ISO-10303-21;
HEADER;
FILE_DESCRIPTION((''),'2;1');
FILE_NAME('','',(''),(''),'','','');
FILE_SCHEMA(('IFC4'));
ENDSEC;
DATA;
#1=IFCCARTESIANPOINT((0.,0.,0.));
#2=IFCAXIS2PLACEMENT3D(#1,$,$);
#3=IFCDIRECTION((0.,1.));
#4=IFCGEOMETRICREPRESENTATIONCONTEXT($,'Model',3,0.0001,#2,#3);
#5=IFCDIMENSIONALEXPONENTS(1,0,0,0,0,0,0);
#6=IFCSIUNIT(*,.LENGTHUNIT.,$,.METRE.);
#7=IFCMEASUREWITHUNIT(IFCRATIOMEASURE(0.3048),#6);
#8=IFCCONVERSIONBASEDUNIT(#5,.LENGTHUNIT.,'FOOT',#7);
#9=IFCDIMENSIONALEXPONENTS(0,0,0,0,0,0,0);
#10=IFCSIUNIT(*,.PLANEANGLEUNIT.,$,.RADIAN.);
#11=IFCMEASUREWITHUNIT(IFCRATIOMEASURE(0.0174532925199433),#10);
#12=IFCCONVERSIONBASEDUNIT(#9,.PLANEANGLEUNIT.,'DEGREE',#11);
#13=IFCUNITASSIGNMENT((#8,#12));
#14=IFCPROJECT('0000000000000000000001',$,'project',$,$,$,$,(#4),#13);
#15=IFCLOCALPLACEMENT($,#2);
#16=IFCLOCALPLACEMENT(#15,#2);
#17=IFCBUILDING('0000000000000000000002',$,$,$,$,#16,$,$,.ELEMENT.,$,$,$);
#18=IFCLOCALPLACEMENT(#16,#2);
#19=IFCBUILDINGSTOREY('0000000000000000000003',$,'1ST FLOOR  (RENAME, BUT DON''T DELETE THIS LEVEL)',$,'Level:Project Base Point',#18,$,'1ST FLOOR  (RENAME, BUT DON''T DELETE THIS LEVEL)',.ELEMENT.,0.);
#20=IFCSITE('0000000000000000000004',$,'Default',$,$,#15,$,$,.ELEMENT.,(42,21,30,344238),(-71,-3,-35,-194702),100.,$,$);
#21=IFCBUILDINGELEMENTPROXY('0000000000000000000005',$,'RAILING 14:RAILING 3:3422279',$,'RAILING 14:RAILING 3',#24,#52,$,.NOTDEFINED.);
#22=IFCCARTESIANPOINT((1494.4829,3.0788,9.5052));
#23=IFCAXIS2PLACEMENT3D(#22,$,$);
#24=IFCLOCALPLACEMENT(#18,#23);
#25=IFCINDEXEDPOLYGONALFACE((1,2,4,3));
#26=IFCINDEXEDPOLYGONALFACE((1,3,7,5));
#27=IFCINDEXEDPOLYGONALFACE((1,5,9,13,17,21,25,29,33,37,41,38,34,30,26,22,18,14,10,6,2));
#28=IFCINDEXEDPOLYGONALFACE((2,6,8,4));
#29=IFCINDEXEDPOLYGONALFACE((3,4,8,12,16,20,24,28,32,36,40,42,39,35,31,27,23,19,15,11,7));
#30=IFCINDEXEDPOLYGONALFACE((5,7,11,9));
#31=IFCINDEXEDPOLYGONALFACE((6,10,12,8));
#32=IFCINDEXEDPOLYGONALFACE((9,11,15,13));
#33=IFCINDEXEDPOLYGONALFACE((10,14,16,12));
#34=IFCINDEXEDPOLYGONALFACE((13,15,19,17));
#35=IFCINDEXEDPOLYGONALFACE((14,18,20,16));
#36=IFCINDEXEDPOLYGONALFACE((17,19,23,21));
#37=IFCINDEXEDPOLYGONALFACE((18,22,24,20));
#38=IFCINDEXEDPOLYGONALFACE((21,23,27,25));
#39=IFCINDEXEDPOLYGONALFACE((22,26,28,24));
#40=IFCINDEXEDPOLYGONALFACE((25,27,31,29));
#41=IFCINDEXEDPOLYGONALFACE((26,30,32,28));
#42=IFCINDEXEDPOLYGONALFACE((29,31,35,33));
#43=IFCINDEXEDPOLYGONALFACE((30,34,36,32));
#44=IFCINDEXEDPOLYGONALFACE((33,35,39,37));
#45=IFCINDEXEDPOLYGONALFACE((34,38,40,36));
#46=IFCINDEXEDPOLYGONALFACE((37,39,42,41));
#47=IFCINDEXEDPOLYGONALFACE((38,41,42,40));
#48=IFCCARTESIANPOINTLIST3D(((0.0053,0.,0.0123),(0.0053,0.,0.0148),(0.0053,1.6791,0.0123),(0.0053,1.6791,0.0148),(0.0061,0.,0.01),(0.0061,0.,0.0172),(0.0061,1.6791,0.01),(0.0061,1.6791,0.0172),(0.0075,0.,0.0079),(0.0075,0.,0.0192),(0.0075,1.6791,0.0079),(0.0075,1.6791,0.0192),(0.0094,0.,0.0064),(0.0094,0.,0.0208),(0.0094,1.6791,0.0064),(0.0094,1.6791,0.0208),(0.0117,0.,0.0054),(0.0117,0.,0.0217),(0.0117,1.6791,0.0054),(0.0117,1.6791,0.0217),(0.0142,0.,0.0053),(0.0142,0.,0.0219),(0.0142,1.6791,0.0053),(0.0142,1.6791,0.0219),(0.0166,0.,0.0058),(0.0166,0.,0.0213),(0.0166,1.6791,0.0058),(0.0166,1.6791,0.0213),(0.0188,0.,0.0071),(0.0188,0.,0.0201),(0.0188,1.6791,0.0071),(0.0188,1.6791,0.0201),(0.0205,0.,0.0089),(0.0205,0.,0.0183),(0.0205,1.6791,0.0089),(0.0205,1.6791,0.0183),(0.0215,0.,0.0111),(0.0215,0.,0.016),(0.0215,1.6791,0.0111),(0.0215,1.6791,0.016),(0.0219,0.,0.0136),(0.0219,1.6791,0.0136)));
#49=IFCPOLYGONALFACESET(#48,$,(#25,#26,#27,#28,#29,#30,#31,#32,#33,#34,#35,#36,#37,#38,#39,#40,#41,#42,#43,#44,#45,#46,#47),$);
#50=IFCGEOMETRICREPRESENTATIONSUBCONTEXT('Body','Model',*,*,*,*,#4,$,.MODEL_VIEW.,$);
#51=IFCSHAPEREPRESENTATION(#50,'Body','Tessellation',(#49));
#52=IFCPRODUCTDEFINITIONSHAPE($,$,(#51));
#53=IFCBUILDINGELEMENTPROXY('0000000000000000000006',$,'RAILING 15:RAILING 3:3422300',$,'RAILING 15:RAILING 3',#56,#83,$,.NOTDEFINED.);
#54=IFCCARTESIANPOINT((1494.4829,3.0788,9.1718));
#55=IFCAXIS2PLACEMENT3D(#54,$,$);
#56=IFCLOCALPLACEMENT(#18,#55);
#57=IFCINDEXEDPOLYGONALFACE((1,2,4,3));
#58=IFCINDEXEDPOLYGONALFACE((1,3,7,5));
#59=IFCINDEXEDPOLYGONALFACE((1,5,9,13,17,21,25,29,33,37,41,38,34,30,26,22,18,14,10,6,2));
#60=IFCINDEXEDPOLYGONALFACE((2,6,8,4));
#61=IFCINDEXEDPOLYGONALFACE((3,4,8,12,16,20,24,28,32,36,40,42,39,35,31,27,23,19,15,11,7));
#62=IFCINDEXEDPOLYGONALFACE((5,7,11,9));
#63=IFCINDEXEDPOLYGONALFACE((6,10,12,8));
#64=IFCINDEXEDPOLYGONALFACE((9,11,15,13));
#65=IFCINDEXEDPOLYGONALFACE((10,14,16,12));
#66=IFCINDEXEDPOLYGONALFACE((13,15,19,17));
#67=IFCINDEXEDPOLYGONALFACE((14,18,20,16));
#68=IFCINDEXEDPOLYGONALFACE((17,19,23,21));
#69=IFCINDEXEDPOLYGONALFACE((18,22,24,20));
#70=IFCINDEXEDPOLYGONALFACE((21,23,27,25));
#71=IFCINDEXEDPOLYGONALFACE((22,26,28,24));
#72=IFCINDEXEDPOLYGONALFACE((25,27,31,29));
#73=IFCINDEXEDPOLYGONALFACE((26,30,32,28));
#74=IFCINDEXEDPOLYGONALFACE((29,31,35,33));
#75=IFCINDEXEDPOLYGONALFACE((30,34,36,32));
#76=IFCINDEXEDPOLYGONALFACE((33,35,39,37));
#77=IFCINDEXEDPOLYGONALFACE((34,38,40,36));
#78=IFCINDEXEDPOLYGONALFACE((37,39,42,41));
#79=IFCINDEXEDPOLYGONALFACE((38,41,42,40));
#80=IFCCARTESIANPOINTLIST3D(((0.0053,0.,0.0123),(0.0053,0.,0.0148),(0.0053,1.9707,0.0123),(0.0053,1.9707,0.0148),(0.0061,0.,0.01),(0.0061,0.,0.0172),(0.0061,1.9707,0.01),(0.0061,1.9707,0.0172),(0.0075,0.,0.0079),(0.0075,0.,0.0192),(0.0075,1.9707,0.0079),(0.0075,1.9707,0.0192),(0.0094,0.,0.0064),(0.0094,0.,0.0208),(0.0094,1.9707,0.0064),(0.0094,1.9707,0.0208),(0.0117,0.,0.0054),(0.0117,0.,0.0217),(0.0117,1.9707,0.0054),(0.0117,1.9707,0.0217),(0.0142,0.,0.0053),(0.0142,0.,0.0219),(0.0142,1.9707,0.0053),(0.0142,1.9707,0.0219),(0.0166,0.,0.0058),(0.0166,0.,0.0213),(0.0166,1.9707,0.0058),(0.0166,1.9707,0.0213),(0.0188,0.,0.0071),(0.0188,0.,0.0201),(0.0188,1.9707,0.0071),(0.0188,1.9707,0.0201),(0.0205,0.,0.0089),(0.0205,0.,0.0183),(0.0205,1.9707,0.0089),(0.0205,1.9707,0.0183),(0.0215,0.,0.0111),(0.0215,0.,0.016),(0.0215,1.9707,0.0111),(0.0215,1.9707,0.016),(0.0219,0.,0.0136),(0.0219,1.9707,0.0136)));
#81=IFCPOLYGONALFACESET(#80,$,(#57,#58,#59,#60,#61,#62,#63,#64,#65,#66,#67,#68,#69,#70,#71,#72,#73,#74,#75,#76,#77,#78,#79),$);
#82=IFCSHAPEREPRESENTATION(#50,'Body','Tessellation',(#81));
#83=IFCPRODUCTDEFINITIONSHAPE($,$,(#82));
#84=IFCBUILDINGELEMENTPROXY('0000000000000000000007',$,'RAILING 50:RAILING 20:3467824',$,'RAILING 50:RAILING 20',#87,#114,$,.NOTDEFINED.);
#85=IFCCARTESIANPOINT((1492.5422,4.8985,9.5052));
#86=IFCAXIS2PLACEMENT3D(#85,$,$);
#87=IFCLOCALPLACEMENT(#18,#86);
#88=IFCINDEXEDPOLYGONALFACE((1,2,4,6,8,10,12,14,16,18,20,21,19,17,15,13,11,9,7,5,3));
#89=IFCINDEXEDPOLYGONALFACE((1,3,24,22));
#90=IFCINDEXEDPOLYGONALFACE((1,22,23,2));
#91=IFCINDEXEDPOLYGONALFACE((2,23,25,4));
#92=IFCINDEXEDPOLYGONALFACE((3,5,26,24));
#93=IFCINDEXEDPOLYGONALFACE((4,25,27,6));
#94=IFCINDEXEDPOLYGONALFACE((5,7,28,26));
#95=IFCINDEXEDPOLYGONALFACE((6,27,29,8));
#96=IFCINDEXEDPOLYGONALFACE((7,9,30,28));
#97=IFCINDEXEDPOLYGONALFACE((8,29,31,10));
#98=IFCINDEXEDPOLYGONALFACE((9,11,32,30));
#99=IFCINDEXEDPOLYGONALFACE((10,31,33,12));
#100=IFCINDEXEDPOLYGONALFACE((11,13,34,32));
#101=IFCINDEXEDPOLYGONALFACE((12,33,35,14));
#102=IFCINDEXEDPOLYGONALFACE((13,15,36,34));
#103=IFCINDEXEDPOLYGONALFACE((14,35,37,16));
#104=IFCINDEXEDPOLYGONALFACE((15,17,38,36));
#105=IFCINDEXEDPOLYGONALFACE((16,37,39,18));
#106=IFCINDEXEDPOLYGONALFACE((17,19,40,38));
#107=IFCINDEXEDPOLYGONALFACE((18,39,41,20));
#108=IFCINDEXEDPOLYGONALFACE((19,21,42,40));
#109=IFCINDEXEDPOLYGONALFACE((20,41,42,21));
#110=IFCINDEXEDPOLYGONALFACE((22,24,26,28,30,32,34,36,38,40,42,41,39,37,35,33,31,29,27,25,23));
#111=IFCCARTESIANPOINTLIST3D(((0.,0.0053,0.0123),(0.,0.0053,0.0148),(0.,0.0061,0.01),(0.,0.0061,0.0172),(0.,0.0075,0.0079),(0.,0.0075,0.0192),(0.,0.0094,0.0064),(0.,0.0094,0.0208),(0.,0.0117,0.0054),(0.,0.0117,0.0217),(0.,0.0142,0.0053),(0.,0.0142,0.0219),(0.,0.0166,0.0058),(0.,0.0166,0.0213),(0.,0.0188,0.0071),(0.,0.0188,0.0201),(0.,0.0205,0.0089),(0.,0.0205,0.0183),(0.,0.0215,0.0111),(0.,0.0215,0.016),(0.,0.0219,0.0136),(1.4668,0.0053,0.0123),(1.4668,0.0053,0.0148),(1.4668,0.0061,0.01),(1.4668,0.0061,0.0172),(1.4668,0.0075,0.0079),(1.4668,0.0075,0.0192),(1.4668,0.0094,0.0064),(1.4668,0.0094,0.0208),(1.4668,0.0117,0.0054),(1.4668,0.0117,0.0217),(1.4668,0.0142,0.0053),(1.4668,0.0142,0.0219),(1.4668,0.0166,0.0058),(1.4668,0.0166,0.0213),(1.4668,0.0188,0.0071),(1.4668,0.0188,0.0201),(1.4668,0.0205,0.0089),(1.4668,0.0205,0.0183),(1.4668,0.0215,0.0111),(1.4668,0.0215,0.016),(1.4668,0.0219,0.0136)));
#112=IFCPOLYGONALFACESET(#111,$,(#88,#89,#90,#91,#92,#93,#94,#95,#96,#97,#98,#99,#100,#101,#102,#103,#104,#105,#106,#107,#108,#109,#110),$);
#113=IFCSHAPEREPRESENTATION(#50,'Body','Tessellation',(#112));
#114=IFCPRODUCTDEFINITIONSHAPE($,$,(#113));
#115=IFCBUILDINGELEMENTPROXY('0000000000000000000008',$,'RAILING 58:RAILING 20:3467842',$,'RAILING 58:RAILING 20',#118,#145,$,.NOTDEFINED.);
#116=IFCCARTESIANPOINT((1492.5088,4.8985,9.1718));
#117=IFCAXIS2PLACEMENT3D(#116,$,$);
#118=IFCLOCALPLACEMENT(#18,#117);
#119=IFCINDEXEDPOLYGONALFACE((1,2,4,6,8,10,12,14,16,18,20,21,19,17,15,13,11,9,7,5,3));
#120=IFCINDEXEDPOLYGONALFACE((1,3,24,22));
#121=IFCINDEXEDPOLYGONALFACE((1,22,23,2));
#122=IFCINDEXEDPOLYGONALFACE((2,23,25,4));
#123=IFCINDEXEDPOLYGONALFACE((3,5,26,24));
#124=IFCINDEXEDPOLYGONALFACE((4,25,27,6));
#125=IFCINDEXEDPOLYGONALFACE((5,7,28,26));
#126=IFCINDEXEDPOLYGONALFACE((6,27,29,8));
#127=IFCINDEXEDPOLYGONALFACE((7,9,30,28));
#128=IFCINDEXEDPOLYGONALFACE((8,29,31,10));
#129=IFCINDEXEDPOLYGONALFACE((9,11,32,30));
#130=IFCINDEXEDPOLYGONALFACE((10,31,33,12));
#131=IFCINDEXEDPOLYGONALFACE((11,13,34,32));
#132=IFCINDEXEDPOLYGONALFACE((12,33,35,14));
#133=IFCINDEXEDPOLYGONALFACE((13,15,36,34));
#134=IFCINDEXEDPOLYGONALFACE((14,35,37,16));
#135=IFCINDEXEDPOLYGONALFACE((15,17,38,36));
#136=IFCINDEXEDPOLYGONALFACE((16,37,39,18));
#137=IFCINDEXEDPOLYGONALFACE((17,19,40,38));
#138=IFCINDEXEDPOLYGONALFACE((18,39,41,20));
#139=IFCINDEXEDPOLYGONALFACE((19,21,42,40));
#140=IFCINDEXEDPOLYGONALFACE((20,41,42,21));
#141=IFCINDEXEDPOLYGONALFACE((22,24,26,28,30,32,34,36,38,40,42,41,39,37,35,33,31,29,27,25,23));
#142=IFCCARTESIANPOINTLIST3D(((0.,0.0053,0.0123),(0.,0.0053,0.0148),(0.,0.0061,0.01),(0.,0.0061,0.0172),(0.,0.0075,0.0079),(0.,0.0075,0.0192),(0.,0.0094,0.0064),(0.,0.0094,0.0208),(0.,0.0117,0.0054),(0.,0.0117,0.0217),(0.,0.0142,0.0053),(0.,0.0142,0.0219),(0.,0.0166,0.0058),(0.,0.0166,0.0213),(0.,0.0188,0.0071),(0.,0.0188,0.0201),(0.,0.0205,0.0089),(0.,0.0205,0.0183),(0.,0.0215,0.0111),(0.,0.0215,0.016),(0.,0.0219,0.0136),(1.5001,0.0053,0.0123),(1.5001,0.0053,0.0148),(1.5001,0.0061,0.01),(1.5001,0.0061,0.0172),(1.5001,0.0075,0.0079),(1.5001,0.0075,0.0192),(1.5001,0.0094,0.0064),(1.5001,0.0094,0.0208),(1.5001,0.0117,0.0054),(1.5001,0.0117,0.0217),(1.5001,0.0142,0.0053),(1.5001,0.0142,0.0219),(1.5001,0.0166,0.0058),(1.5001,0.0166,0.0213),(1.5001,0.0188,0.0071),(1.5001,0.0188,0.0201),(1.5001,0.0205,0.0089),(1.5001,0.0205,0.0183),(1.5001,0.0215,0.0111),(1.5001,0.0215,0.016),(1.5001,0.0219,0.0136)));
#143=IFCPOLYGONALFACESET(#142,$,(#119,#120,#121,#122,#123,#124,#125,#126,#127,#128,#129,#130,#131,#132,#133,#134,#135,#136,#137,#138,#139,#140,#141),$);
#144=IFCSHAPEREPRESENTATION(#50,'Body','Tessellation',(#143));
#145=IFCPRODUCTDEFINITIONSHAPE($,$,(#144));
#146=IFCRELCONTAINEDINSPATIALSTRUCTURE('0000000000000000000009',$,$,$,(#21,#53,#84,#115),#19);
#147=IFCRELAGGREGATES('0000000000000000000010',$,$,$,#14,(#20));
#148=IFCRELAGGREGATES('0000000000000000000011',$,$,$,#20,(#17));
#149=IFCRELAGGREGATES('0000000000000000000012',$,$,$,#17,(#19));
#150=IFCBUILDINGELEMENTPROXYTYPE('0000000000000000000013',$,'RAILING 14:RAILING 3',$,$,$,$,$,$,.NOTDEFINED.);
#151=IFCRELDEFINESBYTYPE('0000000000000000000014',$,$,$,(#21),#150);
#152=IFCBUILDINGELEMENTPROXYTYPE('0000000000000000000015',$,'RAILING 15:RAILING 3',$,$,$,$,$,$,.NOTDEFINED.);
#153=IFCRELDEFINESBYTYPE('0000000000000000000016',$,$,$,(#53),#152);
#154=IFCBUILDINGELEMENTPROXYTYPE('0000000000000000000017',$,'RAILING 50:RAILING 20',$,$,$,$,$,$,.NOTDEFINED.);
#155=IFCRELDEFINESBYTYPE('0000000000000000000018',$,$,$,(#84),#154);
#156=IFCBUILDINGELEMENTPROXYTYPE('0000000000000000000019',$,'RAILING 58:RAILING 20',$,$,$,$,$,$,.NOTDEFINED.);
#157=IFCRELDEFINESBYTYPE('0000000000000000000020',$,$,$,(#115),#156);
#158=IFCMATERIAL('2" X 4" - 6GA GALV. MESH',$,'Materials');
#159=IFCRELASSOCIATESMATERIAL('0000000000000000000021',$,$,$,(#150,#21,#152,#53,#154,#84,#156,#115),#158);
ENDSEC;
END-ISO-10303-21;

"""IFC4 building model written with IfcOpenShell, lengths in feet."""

from ifc_helpers import new_model, entity, si_unit, converted_unit, direction, frame, origin, origin_2d_with_axis, place, context, subcontext, project, spatial, circle, extrude, source, transform, mapped, material, type_object, type_shapes, element, save


model = new_model("IFC4")

# Units and contexts
model_context = context("Model", 3, precision=0.0001, world=origin(), true_north=direction((0.0, 1.0)))
body_context = subcontext(model_context, "Body", "Model", "MODEL_VIEW")
ifc_project = project(units=[converted_unit("LENGTHUNIT", "FOOT", entity("IfcRatioMeasure", 0.3048), si_unit("LENGTHUNIT", "METRE"), dimensions=[1, 0, 0, 0, 0, 0, 0]), converted_unit("PLANEANGLEUNIT", "DEGREE", entity("IfcRatioMeasure", 0.0174532925199433), si_unit("PLANEANGLEUNIT", "RADIAN"), dimensions=[0, 0, 0, 0, 0, 0, 0])], contexts=[model_context])

# Site, building, storey
site_placement = place(None, origin())
site = spatial("IfcSite", under=ifc_project, at=site_placement, Name="Default", CompositionType="ELEMENT", RefLatitude=(42, 21, 30, 344238), RefLongitude=(-71, -3, -35, -194702), RefElevation=100.0)
building_placement = place(site_placement, origin())
building = spatial("IfcBuilding", under=site, at=building_placement, CompositionType="ELEMENT")
storey_placement = place(building_placement, origin())
storey = spatial("IfcBuildingStorey", under=building, at=storey_placement, Name="1ST FLOOR  (RENAME, BUT DON'T DELETE THIS LEVEL)", ObjectType="Level:Project Base Point", LongName="1ST FLOOR  (RENAME, BUT DON'T DELETE THIS LEVEL)", CompositionType="ELEMENT", Elevation=0.0)

# Building element proxies
ifc_material_1 = material(Name="2\" X 4\" - 6GA GALV. MESH", Category="Materials")
building_element_proxy_type_1 = type_object("IfcBuildingElementProxyType", Name="RAILING 14:RAILING 3", PredefinedType="NOTDEFINED", material=ifc_material_1)
shared_shape_1 = source(origin(), body_context, "Body", "SweptSolid", [
    extrude(circle(Radius=0.0083, at=origin_2d_with_axis()), frame((0.0136, 0.0, 0.0136), z_axis=(0.0, 1.0, 0.0), x_axis=(1.0, 0.0, 0.0)), (0.0, 0.0, 1.0), 1.6791),
])
type_shapes(building_element_proxy_type_1, [shared_shape_1])
proxy_1_placement = place(storey_placement, frame((1494.4829, 3.0788, 9.5052)))
element("IfcBuildingElementProxy", 1, at=proxy_1_placement, inside=storey, type_object=building_element_proxy_type_1, material=ifc_material_1, Name="RAILING 14:RAILING 3:3422279", ObjectType="RAILING 14:RAILING 3", PredefinedType="NOTDEFINED", context=body_context, shape_type="MappedRepresentation", body=[
    mapped(shared_shape_1, transform((0.0, 0.0, 0.0), scale=1.0)),
])
building_element_proxy_type_2 = type_object("IfcBuildingElementProxyType", Name="RAILING 15:RAILING 3", PredefinedType="NOTDEFINED", material=ifc_material_1)
shared_shape_2 = source(origin(), body_context, "Body", "SweptSolid", [
    extrude(circle(Radius=0.0083, at=origin_2d_with_axis()), frame((0.0136, 0.0, 0.0136), z_axis=(0.0, 1.0, 0.0), x_axis=(1.0, 0.0, 0.0)), (0.0, 0.0, 1.0), 1.9707),
])
type_shapes(building_element_proxy_type_2, [shared_shape_2])
proxy_2_placement = place(storey_placement, frame((1494.4829, 3.0788, 9.1718)))
element("IfcBuildingElementProxy", 2, at=proxy_2_placement, inside=storey, type_object=building_element_proxy_type_2, material=ifc_material_1, Name="RAILING 15:RAILING 3:3422300", ObjectType="RAILING 15:RAILING 3", PredefinedType="NOTDEFINED", context=body_context, shape_type="MappedRepresentation", body=[
    mapped(shared_shape_2, transform((0.0, 0.0, 0.0), scale=1.0)),
])
building_element_proxy_type_3 = type_object("IfcBuildingElementProxyType", Name="RAILING 50:RAILING 20", PredefinedType="NOTDEFINED", material=ifc_material_1)
shared_shape_3 = source(origin(), body_context, "Body", "SweptSolid", [
    extrude(circle(Radius=0.0083, at=origin_2d_with_axis()), frame((0.0, 0.0136, 0.0136), z_axis=(1.0, 0.0, 0.0), x_axis=(0.0, 1.0, 0.0)), (0.0, 0.0, 1.0), 1.4668),
])
type_shapes(building_element_proxy_type_3, [shared_shape_3])
proxy_3_placement = place(storey_placement, frame((1492.5422, 4.8985, 9.5052)))
element("IfcBuildingElementProxy", 3, at=proxy_3_placement, inside=storey, type_object=building_element_proxy_type_3, material=ifc_material_1, Name="RAILING 50:RAILING 20:3467824", ObjectType="RAILING 50:RAILING 20", PredefinedType="NOTDEFINED", context=body_context, shape_type="MappedRepresentation", body=[
    mapped(shared_shape_3, transform((0.0, 0.0, 0.0), scale=1.0)),
])
building_element_proxy_type_4 = type_object("IfcBuildingElementProxyType", Name="RAILING 58:RAILING 20", PredefinedType="NOTDEFINED", material=ifc_material_1)
shared_shape_4 = source(origin(), body_context, "Body", "SweptSolid", [
    extrude(circle(Radius=0.0083, at=origin_2d_with_axis()), frame((0.0, 0.0136, 0.0136), z_axis=(1.0, 0.0, 0.0), x_axis=(0.0, 1.0, 0.0)), (0.0, 0.0, 1.0), 1.5001),
])
type_shapes(building_element_proxy_type_4, [shared_shape_4])
proxy_4_placement = place(storey_placement, frame((1492.5088, 4.8985, 9.1718)))
element("IfcBuildingElementProxy", 4, at=proxy_4_placement, inside=storey, type_object=building_element_proxy_type_4, material=ifc_material_1, Name="RAILING 58:RAILING 20:3467842", ObjectType="RAILING 58:RAILING 20", PredefinedType="NOTDEFINED", context=body_context, shape_type="MappedRepresentation", body=[
    mapped(shared_shape_4, transform((0.0, 0.0, 0.0), scale=1.0)),
])

save(model, "model.ifc")
